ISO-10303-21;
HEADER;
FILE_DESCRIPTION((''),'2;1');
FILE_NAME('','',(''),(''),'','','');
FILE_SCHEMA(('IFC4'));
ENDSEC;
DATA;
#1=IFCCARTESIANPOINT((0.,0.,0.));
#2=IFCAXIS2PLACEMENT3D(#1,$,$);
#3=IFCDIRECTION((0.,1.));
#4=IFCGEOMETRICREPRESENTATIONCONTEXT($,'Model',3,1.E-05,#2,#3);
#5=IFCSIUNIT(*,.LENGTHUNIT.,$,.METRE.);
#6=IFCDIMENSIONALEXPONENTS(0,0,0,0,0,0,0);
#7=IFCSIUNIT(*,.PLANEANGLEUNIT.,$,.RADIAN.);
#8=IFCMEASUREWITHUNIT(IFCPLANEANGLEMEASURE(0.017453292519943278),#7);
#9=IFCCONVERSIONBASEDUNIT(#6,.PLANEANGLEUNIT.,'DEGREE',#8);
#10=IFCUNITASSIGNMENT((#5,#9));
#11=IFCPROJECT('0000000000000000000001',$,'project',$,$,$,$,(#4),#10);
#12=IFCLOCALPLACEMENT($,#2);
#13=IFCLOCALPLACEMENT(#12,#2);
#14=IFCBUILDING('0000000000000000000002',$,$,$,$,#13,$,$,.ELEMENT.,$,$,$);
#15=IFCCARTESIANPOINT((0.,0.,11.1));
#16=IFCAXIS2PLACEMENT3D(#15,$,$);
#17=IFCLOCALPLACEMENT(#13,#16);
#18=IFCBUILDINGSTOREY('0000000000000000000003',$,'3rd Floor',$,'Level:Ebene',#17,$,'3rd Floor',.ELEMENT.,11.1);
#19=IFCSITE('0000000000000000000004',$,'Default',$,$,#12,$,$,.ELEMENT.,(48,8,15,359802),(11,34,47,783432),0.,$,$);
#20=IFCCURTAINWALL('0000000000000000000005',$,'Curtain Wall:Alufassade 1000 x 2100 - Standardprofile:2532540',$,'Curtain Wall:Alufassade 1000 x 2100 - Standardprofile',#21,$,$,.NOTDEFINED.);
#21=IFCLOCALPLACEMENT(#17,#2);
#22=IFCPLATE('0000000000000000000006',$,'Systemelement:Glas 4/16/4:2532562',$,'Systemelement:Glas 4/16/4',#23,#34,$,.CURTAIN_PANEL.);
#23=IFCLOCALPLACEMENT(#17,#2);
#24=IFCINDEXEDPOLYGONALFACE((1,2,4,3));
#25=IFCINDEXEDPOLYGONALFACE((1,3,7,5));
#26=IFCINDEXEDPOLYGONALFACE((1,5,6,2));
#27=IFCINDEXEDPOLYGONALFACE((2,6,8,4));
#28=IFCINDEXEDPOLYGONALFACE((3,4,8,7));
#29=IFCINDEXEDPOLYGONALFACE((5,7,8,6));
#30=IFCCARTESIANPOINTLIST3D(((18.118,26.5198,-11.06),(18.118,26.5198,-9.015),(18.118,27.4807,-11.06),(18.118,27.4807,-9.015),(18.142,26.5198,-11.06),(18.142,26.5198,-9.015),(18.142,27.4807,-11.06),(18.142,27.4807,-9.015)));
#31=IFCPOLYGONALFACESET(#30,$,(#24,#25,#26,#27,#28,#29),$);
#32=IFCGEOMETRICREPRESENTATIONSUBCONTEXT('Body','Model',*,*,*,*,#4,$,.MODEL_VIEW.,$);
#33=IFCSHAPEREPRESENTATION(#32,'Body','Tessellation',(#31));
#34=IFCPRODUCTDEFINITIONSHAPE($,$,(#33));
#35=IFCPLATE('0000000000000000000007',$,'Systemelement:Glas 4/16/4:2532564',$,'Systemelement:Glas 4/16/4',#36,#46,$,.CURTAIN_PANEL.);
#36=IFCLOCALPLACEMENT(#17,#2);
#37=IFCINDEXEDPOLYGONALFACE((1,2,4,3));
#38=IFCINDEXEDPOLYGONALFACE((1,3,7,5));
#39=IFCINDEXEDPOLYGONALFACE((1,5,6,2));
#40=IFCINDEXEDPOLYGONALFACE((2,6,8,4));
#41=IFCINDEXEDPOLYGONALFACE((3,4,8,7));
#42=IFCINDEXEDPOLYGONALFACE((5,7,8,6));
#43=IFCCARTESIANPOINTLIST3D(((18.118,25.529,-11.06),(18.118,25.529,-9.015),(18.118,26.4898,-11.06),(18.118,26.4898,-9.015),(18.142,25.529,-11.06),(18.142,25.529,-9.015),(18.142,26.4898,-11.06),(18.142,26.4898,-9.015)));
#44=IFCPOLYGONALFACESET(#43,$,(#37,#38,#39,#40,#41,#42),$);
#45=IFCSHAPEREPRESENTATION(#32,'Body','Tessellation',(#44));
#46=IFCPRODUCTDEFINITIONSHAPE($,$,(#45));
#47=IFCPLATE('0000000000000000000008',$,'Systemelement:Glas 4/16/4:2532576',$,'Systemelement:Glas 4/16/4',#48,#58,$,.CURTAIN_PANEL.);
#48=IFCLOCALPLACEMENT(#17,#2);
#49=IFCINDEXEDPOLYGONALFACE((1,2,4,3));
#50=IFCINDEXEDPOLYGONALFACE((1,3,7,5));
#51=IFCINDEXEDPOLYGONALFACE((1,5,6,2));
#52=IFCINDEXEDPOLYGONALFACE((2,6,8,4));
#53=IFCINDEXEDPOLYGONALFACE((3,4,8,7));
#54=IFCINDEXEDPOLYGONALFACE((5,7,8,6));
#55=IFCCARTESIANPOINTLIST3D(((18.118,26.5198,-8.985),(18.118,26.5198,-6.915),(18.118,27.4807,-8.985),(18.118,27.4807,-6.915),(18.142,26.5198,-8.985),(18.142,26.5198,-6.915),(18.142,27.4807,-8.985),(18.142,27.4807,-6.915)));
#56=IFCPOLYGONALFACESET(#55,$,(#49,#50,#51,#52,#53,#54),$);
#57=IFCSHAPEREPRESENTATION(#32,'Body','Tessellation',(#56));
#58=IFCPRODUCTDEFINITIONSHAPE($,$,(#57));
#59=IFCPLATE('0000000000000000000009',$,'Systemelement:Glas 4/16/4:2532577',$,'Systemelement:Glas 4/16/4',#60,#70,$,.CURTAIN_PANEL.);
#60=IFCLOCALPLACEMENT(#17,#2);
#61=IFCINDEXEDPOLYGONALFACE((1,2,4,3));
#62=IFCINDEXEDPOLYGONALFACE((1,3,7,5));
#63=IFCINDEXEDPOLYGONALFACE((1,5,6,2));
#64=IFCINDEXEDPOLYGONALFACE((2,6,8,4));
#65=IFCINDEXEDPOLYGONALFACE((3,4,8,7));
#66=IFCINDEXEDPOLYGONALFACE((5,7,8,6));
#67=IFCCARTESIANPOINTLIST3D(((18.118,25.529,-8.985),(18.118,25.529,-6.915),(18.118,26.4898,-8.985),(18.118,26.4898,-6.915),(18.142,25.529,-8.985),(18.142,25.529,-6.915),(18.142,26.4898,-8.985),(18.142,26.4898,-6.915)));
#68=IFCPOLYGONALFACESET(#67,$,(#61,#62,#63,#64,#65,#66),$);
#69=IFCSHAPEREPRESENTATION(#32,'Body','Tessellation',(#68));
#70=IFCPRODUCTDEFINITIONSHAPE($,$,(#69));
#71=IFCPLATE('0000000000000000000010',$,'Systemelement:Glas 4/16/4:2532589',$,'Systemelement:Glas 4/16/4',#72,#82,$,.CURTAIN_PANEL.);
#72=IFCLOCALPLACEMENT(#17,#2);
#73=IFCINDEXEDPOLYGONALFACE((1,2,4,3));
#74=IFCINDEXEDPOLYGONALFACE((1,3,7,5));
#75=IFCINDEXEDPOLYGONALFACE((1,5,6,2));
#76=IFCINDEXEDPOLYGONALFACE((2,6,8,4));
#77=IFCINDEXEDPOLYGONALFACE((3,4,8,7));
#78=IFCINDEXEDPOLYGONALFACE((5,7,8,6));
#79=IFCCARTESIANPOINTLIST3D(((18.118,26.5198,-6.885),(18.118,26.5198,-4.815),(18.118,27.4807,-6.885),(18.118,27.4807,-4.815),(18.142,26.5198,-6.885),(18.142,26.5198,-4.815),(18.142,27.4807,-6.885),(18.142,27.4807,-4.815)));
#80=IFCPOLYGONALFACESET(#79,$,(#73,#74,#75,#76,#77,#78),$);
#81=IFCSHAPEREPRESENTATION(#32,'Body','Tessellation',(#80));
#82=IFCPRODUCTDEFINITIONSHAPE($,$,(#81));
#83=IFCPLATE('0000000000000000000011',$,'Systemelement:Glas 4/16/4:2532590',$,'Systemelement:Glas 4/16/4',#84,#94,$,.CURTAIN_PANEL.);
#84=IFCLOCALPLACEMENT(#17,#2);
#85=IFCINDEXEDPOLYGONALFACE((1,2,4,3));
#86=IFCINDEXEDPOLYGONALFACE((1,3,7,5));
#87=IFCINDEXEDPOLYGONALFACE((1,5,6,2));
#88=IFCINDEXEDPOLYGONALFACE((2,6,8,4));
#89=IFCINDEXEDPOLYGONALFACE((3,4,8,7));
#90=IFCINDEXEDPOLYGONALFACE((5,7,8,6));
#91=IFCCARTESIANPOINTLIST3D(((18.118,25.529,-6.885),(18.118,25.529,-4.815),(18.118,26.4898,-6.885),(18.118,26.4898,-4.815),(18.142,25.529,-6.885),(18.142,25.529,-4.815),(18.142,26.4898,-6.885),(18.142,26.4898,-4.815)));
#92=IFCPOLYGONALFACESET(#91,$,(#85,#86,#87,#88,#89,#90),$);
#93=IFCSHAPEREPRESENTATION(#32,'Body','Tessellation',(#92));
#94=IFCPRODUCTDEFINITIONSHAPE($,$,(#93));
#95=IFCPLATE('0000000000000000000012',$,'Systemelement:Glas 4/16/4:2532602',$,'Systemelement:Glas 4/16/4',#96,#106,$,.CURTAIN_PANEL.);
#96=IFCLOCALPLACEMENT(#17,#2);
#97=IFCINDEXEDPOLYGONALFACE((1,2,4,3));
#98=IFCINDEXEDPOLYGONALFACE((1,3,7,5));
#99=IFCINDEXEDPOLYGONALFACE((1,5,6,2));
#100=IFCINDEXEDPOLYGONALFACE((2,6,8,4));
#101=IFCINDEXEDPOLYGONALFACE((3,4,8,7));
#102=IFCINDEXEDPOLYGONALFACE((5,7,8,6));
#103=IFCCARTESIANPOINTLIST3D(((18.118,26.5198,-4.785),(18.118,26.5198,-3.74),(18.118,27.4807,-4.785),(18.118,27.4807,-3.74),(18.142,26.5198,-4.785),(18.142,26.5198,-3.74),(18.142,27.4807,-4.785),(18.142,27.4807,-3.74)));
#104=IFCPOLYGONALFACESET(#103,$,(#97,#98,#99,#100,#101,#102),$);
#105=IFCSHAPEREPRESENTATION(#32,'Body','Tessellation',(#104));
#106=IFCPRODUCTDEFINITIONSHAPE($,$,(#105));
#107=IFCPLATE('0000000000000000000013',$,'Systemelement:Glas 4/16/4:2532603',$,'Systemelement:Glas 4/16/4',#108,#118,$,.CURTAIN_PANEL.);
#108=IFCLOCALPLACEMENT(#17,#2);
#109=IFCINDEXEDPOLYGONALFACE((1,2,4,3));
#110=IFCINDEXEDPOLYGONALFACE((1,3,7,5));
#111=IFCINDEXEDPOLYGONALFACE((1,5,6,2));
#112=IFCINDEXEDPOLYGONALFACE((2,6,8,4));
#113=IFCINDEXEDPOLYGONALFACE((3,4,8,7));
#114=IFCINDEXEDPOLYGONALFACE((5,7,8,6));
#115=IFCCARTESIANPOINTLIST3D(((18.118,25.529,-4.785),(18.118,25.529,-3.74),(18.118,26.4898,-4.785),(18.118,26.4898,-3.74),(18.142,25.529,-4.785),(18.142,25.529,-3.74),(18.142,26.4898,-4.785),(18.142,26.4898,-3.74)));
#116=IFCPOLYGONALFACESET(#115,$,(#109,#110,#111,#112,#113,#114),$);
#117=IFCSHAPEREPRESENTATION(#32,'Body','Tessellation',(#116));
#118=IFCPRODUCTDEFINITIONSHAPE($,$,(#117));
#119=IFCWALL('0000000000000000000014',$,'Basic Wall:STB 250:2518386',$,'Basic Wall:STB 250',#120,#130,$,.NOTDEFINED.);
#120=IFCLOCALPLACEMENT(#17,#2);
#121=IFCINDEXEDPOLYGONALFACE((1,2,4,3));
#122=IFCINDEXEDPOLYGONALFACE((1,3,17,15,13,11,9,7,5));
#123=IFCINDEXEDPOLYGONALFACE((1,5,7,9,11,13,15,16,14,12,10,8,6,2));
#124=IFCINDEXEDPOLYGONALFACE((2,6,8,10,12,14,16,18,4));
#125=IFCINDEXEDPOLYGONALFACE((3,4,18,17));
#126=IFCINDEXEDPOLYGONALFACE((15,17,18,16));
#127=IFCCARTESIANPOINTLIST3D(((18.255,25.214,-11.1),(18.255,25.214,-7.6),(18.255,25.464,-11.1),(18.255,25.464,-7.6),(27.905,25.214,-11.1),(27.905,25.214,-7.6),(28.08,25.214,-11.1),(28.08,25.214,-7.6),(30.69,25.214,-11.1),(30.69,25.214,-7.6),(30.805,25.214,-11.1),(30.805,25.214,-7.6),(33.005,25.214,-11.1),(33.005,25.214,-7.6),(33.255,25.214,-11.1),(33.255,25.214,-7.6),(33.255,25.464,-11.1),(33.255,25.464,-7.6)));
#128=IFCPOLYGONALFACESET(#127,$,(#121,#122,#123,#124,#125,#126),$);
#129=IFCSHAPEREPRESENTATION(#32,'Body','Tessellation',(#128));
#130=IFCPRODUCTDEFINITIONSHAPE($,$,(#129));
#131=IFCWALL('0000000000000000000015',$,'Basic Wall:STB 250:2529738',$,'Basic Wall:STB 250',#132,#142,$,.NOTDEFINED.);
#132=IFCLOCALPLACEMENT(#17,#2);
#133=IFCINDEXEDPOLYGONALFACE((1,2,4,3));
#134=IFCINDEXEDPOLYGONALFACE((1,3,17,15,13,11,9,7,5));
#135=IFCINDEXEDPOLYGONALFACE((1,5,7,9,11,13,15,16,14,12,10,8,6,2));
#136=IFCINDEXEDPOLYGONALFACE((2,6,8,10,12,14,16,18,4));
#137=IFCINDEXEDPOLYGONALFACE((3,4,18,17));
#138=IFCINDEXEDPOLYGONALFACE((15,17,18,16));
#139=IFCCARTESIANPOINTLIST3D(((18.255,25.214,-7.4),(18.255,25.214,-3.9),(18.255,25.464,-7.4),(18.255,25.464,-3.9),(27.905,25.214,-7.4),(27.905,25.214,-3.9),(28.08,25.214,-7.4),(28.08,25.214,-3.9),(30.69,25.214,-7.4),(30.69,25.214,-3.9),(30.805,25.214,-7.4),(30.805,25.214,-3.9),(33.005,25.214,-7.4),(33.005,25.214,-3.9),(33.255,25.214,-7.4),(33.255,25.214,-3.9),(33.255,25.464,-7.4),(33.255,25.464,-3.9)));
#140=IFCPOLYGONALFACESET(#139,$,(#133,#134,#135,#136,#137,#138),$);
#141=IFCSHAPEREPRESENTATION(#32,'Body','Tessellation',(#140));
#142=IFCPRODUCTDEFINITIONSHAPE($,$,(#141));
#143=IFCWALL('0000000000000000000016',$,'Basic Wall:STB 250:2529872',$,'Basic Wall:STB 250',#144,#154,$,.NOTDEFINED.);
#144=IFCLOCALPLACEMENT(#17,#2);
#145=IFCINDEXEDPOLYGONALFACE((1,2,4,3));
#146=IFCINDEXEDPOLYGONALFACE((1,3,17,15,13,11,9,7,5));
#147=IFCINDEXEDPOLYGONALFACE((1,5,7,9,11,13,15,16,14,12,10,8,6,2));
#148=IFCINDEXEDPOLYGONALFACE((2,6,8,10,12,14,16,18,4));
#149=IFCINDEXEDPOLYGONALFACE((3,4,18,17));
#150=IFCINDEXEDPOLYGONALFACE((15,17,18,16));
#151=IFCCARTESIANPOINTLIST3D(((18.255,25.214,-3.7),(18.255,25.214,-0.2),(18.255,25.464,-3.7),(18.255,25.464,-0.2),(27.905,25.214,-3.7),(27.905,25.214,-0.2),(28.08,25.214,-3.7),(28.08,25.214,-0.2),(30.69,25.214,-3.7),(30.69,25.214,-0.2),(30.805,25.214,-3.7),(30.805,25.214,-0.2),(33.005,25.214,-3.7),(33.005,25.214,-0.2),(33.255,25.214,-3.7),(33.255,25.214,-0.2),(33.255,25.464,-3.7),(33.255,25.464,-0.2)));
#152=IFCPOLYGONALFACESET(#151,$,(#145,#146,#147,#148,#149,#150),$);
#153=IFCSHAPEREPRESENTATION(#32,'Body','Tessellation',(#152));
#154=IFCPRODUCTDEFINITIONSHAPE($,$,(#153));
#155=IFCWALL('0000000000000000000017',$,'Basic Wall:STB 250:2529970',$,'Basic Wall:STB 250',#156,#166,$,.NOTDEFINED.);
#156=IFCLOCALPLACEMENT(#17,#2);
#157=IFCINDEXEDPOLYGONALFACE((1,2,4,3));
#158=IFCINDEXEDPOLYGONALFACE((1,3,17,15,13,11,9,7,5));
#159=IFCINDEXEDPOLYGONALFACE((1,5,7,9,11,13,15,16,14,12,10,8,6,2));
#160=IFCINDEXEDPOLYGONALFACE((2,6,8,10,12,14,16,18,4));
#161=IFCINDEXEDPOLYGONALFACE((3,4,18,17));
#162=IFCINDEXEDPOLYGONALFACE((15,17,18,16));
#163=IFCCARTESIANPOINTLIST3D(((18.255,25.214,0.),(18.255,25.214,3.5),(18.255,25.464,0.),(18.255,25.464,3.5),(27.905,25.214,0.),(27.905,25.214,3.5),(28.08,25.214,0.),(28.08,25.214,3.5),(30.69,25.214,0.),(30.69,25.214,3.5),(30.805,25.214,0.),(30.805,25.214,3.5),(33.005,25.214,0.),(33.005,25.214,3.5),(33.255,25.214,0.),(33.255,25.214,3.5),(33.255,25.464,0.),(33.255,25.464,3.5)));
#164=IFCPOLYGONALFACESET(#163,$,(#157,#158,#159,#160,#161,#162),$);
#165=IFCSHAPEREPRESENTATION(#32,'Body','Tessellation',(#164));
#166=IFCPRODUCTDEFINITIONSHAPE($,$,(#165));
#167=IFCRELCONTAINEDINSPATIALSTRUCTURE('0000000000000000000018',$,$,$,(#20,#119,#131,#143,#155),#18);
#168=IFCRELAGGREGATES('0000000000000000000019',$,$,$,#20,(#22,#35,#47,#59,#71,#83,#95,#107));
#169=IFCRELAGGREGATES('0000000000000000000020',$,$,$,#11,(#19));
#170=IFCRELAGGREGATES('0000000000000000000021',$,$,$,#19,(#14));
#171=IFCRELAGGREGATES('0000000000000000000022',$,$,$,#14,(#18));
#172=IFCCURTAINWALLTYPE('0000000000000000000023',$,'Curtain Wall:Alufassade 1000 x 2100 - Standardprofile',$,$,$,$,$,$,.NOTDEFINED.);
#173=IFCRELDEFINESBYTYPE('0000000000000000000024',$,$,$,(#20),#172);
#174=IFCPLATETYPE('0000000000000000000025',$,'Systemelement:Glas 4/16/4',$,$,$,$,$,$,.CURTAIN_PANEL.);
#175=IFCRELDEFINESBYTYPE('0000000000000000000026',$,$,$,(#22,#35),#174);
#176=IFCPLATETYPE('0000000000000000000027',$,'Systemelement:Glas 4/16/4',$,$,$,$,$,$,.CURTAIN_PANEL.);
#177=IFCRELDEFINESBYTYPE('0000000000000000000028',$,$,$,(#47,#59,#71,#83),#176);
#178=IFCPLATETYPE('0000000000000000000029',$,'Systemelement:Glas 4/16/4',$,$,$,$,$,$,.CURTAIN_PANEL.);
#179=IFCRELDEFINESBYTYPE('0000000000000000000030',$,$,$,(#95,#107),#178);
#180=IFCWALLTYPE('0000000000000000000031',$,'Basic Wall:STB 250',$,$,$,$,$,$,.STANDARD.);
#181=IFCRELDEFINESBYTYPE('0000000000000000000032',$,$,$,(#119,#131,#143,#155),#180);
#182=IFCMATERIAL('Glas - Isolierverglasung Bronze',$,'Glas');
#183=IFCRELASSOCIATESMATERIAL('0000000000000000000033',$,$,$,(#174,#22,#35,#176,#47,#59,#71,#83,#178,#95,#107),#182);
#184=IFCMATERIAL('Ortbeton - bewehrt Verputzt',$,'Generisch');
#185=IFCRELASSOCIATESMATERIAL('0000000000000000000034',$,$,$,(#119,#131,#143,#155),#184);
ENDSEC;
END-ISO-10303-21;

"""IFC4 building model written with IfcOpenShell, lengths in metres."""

from ifc_helpers import new_model, entity, si_unit, converted_unit, direction, frame, origin, place, context, subcontext, project, spatial, indexed_curve, outline, extrude, source, transform, mapped, material, type_object, type_shapes, element, aggregate, save


model = new_model("IFC4")

# Units and contexts
model_context = context("Model", 3, precision=1e-05, world=origin(), true_north=direction((0.0, 1.0)))
body_context = subcontext(model_context, "Body", "Model", "MODEL_VIEW")
ifc_project = project(units=[si_unit("LENGTHUNIT", "METRE"), converted_unit("PLANEANGLEUNIT", "DEGREE", entity("IfcPlaneAngleMeasure", 0.017453292519943278), si_unit("PLANEANGLEUNIT", "RADIAN"), dimensions=[0, 0, 0, 0, 0, 0, 0])], contexts=[model_context])

# Site, building, storey
site_placement = place(None, origin())
site = spatial("IfcSite", under=ifc_project, at=site_placement, Name="Default", CompositionType="ELEMENT", RefLatitude=(48, 8, 15, 359802), RefLongitude=(11, 34, 47, 783432), RefElevation=0.0)
building_placement = place(site_placement, origin())
building = spatial("IfcBuilding", under=site, at=building_placement, CompositionType="ELEMENT")
storey_placement = place(building_placement, frame((0.0, 0.0, 11.1)))
storey = spatial("IfcBuildingStorey", under=building, at=storey_placement, Name="3rd Floor", ObjectType="Level:Ebene", LongName="3rd Floor", CompositionType="ELEMENT", Elevation=11.1)

# Curtain wall, plates
curtain_wall_type = type_object("IfcCurtainWallType", Name="Curtain Wall:Alufassade 1000 x 2100 - Standardprofile", PredefinedType="NOTDEFINED")
curtain_wall_placement = place(storey_placement, frame((0.0, 0.0, -11.1)))
curtain_wall = element("IfcCurtainWall", 1, at=curtain_wall_placement, inside=storey, type_object=curtain_wall_type, Name="Curtain Wall:Alufassade 1000 x 2100 - Standardprofile:2532540", ObjectType="Curtain Wall:Alufassade 1000 x 2100 - Standardprofile", PredefinedType="NOTDEFINED")
ifc_material_1 = material(Name="Glas - Isolierverglasung Bronze", Category="Glas")
plate_type_1 = type_object("IfcPlateType", Name="Systemelement:Glas 4/16/4", PredefinedType="CURTAIN_PANEL", material=ifc_material_1)
shared_shape_1 = source(origin(), body_context, "Body", "SweptSolid", [
    extrude(outline(indexed_curve([(-0.012, -0.4804), (0.012, -0.4804), (0.012, 0.4804), (-0.012, 0.4804), (-0.012, -0.4804)], self_intersect=False)), frame((0.0, 0.0, 0.0), z_axis=(0.0, 0.0, 1.0), x_axis=(0.0, 1.0, 0.0)), (0.0, 0.0, 1.0), 2.045),
])
type_shapes(plate_type_1, [shared_shape_1])
plate_1_placement = place(curtain_wall_placement, frame((18.13, 27.0003, 0.04), z_axis=(0.0, 0.0, 1.0), x_axis=(0.0, -1.0, 0.0)))
plate_1 = element("IfcPlate", 2, at=plate_1_placement, type_object=plate_type_1, material=ifc_material_1, Name="Systemelement:Glas 4/16/4:2532562", ObjectType="Systemelement:Glas 4/16/4", PredefinedType="CURTAIN_PANEL", context=body_context, shape_type="MappedRepresentation", body=[
    mapped(shared_shape_1, transform((0.0, 0.0, 0.0), scale=1.0)),
])
plate_2_placement = place(curtain_wall_placement, frame((18.13, 26.0094, 0.04), z_axis=(0.0, 0.0, 1.0), x_axis=(0.0, -1.0, 0.0)))
plate_2 = element("IfcPlate", 3, at=plate_2_placement, type_object=plate_type_1, material=ifc_material_1, Name="Systemelement:Glas 4/16/4:2532564", ObjectType="Systemelement:Glas 4/16/4", PredefinedType="CURTAIN_PANEL", context=body_context, shape_type="MappedRepresentation", body=[
    mapped(shared_shape_1, transform((0.0, 0.0, 0.0), scale=1.0)),
])
plate_type_2 = type_object("IfcPlateType", Name="Systemelement:Glas 4/16/4", PredefinedType="CURTAIN_PANEL", material=ifc_material_1)
shared_shape_2 = source(origin(), body_context, "Body", "SweptSolid", [
    extrude(outline(indexed_curve([(-0.012, -0.4804), (0.012, -0.4804), (0.012, 0.4804), (-0.012, 0.4804), (-0.012, -0.4804)], self_intersect=False)), frame((0.0, 0.0, 0.0), z_axis=(0.0, 0.0, 1.0), x_axis=(0.0, 1.0, 0.0)), (0.0, 0.0, 1.0), 2.07),
])
type_shapes(plate_type_2, [shared_shape_2])
plate_3_placement = place(curtain_wall_placement, frame((18.13, 27.0003, 2.115), z_axis=(0.0, 0.0, 1.0), x_axis=(0.0, -1.0, 0.0)))
plate_3 = element("IfcPlate", 4, at=plate_3_placement, type_object=plate_type_2, material=ifc_material_1, Name="Systemelement:Glas 4/16/4:2532576", ObjectType="Systemelement:Glas 4/16/4", PredefinedType="CURTAIN_PANEL", context=body_context, shape_type="MappedRepresentation", body=[
    mapped(shared_shape_2, transform((0.0, 0.0, 0.0), scale=1.0)),
])
plate_4_placement = place(curtain_wall_placement, frame((18.13, 26.0094, 2.115), z_axis=(0.0, 0.0, 1.0), x_axis=(0.0, -1.0, 0.0)))
plate_4 = element("IfcPlate", 5, at=plate_4_placement, type_object=plate_type_2, material=ifc_material_1, Name="Systemelement:Glas 4/16/4:2532577", ObjectType="Systemelement:Glas 4/16/4", PredefinedType="CURTAIN_PANEL", context=body_context, shape_type="MappedRepresentation", body=[
    mapped(shared_shape_2, transform((0.0, 0.0, 0.0), scale=1.0)),
])
plate_5_placement = place(curtain_wall_placement, frame((18.13, 27.0003, 4.215), z_axis=(0.0, 0.0, 1.0), x_axis=(0.0, -1.0, 0.0)))
plate_5 = element("IfcPlate", 6, at=plate_5_placement, type_object=plate_type_2, material=ifc_material_1, Name="Systemelement:Glas 4/16/4:2532589", ObjectType="Systemelement:Glas 4/16/4", PredefinedType="CURTAIN_PANEL", context=body_context, shape_type="MappedRepresentation", body=[
    mapped(shared_shape_2, transform((0.0, 0.0, 0.0), scale=1.0)),
])
plate_6_placement = place(curtain_wall_placement, frame((18.13, 26.0094, 4.215), z_axis=(0.0, 0.0, 1.0), x_axis=(0.0, -1.0, 0.0)))
plate_6 = element("IfcPlate", 7, at=plate_6_placement, type_object=plate_type_2, material=ifc_material_1, Name="Systemelement:Glas 4/16/4:2532590", ObjectType="Systemelement:Glas 4/16/4", PredefinedType="CURTAIN_PANEL", context=body_context, shape_type="MappedRepresentation", body=[
    mapped(shared_shape_2, transform((0.0, 0.0, 0.0), scale=1.0)),
])
plate_type_3 = type_object("IfcPlateType", Name="Systemelement:Glas 4/16/4", PredefinedType="CURTAIN_PANEL", material=ifc_material_1)
shared_shape_3 = source(origin(), body_context, "Body", "SweptSolid", [
    extrude(outline(indexed_curve([(-0.012, -0.4804), (0.012, -0.4804), (0.012, 0.4804), (-0.012, 0.4804), (-0.012, -0.4804)], self_intersect=False)), frame((0.0, 0.0, 0.0), z_axis=(0.0, 0.0, 1.0), x_axis=(0.0, 1.0, 0.0)), (0.0, 0.0, 1.0), 1.045),
])
type_shapes(plate_type_3, [shared_shape_3])
plate_7_placement = place(curtain_wall_placement, frame((18.13, 27.0003, 6.315), z_axis=(0.0, 0.0, 1.0), x_axis=(0.0, -1.0, 0.0)))
plate_7 = element("IfcPlate", 8, at=plate_7_placement, type_object=plate_type_3, material=ifc_material_1, Name="Systemelement:Glas 4/16/4:2532602", ObjectType="Systemelement:Glas 4/16/4", PredefinedType="CURTAIN_PANEL", context=body_context, shape_type="MappedRepresentation", body=[
    mapped(shared_shape_3, transform((0.0, 0.0, 0.0), scale=1.0)),
])
plate_8_placement = place(curtain_wall_placement, frame((18.13, 26.0094, 6.315), z_axis=(0.0, 0.0, 1.0), x_axis=(0.0, -1.0, 0.0)))
plate_8 = element("IfcPlate", 9, at=plate_8_placement, type_object=plate_type_3, material=ifc_material_1, Name="Systemelement:Glas 4/16/4:2532603", ObjectType="Systemelement:Glas 4/16/4", PredefinedType="CURTAIN_PANEL", context=body_context, shape_type="MappedRepresentation", body=[
    mapped(shared_shape_3, transform((0.0, 0.0, 0.0), scale=1.0)),
])
aggregate(curtain_wall, [plate_1, plate_2, plate_3, plate_4, plate_5, plate_6, plate_7, plate_8])

# Walls
ifc_material_2 = material(Name="Ortbeton - bewehrt Verputzt", Category="Generisch")
wall_type_1 = type_object("IfcWallType", Name="Basic Wall:STB 250", PredefinedType="STANDARD")
wall_1_placement = place(storey_placement, frame((18.255, 25.339, -11.1)))
element("IfcWall", 10, at=wall_1_placement, inside=storey, type_object=wall_type_1, material=ifc_material_2, Name="Basic Wall:STB 250:2518386", ObjectType="Basic Wall:STB 250", PredefinedType="NOTDEFINED", context=body_context, shape_type="SweptSolid", body=[
    extrude(outline(indexed_curve([(15.0, -0.125), (15.0, 0.125), (0.0, 0.125), (0.0, -0.125), (9.65, -0.125), (9.825, -0.125), (12.435, -0.125), (12.55, -0.125), (14.75, -0.125), (15.0, -0.125)], self_intersect=False)), origin(), (0.0, 0.0, 1.0), 3.5),
])
wall_2_placement = place(storey_placement, frame((18.255, 25.339, -7.4)))
element("IfcWall", 11, at=wall_2_placement, inside=storey, type_object=wall_type_1, material=ifc_material_2, Name="Basic Wall:STB 250:2529738", ObjectType="Basic Wall:STB 250", PredefinedType="NOTDEFINED", context=body_context, shape_type="SweptSolid", body=[
    extrude(outline(indexed_curve([(15.0, -0.125), (15.0, 0.125), (0.0, 0.125), (0.0, -0.125), (9.65, -0.125), (9.825, -0.125), (12.435, -0.125), (12.55, -0.125), (14.75, -0.125), (15.0, -0.125)], self_intersect=False)), origin(), (0.0, 0.0, 1.0), 3.5),
])
for number, where, name in (
    (12, (18.255, 25.339, -3.7), "Basic Wall:STB 250:2529872"),
    (13, (18.255, 25.339, 0.0), "Basic Wall:STB 250:2529970"),
):
    element("IfcWall", number, at=place(storey_placement, frame(where)), inside=storey, type_object=wall_type_1, material=ifc_material_2, Name=name, ObjectType="Basic Wall:STB 250", PredefinedType="NOTDEFINED", context=body_context, shape_type="SweptSolid", body=[
        extrude(outline(indexed_curve([(15.0, -0.125), (15.0, 0.125), (0.0, 0.125), (0.0, -0.125), (9.65, -0.125), (9.825, -0.125), (12.435, -0.125), (12.55, -0.125), (14.75, -0.125), (15.0, -0.125)], self_intersect=False)), origin(), (0.0, 0.0, 1.0), 3.5),
    ])

save(model, "model.ifc")
